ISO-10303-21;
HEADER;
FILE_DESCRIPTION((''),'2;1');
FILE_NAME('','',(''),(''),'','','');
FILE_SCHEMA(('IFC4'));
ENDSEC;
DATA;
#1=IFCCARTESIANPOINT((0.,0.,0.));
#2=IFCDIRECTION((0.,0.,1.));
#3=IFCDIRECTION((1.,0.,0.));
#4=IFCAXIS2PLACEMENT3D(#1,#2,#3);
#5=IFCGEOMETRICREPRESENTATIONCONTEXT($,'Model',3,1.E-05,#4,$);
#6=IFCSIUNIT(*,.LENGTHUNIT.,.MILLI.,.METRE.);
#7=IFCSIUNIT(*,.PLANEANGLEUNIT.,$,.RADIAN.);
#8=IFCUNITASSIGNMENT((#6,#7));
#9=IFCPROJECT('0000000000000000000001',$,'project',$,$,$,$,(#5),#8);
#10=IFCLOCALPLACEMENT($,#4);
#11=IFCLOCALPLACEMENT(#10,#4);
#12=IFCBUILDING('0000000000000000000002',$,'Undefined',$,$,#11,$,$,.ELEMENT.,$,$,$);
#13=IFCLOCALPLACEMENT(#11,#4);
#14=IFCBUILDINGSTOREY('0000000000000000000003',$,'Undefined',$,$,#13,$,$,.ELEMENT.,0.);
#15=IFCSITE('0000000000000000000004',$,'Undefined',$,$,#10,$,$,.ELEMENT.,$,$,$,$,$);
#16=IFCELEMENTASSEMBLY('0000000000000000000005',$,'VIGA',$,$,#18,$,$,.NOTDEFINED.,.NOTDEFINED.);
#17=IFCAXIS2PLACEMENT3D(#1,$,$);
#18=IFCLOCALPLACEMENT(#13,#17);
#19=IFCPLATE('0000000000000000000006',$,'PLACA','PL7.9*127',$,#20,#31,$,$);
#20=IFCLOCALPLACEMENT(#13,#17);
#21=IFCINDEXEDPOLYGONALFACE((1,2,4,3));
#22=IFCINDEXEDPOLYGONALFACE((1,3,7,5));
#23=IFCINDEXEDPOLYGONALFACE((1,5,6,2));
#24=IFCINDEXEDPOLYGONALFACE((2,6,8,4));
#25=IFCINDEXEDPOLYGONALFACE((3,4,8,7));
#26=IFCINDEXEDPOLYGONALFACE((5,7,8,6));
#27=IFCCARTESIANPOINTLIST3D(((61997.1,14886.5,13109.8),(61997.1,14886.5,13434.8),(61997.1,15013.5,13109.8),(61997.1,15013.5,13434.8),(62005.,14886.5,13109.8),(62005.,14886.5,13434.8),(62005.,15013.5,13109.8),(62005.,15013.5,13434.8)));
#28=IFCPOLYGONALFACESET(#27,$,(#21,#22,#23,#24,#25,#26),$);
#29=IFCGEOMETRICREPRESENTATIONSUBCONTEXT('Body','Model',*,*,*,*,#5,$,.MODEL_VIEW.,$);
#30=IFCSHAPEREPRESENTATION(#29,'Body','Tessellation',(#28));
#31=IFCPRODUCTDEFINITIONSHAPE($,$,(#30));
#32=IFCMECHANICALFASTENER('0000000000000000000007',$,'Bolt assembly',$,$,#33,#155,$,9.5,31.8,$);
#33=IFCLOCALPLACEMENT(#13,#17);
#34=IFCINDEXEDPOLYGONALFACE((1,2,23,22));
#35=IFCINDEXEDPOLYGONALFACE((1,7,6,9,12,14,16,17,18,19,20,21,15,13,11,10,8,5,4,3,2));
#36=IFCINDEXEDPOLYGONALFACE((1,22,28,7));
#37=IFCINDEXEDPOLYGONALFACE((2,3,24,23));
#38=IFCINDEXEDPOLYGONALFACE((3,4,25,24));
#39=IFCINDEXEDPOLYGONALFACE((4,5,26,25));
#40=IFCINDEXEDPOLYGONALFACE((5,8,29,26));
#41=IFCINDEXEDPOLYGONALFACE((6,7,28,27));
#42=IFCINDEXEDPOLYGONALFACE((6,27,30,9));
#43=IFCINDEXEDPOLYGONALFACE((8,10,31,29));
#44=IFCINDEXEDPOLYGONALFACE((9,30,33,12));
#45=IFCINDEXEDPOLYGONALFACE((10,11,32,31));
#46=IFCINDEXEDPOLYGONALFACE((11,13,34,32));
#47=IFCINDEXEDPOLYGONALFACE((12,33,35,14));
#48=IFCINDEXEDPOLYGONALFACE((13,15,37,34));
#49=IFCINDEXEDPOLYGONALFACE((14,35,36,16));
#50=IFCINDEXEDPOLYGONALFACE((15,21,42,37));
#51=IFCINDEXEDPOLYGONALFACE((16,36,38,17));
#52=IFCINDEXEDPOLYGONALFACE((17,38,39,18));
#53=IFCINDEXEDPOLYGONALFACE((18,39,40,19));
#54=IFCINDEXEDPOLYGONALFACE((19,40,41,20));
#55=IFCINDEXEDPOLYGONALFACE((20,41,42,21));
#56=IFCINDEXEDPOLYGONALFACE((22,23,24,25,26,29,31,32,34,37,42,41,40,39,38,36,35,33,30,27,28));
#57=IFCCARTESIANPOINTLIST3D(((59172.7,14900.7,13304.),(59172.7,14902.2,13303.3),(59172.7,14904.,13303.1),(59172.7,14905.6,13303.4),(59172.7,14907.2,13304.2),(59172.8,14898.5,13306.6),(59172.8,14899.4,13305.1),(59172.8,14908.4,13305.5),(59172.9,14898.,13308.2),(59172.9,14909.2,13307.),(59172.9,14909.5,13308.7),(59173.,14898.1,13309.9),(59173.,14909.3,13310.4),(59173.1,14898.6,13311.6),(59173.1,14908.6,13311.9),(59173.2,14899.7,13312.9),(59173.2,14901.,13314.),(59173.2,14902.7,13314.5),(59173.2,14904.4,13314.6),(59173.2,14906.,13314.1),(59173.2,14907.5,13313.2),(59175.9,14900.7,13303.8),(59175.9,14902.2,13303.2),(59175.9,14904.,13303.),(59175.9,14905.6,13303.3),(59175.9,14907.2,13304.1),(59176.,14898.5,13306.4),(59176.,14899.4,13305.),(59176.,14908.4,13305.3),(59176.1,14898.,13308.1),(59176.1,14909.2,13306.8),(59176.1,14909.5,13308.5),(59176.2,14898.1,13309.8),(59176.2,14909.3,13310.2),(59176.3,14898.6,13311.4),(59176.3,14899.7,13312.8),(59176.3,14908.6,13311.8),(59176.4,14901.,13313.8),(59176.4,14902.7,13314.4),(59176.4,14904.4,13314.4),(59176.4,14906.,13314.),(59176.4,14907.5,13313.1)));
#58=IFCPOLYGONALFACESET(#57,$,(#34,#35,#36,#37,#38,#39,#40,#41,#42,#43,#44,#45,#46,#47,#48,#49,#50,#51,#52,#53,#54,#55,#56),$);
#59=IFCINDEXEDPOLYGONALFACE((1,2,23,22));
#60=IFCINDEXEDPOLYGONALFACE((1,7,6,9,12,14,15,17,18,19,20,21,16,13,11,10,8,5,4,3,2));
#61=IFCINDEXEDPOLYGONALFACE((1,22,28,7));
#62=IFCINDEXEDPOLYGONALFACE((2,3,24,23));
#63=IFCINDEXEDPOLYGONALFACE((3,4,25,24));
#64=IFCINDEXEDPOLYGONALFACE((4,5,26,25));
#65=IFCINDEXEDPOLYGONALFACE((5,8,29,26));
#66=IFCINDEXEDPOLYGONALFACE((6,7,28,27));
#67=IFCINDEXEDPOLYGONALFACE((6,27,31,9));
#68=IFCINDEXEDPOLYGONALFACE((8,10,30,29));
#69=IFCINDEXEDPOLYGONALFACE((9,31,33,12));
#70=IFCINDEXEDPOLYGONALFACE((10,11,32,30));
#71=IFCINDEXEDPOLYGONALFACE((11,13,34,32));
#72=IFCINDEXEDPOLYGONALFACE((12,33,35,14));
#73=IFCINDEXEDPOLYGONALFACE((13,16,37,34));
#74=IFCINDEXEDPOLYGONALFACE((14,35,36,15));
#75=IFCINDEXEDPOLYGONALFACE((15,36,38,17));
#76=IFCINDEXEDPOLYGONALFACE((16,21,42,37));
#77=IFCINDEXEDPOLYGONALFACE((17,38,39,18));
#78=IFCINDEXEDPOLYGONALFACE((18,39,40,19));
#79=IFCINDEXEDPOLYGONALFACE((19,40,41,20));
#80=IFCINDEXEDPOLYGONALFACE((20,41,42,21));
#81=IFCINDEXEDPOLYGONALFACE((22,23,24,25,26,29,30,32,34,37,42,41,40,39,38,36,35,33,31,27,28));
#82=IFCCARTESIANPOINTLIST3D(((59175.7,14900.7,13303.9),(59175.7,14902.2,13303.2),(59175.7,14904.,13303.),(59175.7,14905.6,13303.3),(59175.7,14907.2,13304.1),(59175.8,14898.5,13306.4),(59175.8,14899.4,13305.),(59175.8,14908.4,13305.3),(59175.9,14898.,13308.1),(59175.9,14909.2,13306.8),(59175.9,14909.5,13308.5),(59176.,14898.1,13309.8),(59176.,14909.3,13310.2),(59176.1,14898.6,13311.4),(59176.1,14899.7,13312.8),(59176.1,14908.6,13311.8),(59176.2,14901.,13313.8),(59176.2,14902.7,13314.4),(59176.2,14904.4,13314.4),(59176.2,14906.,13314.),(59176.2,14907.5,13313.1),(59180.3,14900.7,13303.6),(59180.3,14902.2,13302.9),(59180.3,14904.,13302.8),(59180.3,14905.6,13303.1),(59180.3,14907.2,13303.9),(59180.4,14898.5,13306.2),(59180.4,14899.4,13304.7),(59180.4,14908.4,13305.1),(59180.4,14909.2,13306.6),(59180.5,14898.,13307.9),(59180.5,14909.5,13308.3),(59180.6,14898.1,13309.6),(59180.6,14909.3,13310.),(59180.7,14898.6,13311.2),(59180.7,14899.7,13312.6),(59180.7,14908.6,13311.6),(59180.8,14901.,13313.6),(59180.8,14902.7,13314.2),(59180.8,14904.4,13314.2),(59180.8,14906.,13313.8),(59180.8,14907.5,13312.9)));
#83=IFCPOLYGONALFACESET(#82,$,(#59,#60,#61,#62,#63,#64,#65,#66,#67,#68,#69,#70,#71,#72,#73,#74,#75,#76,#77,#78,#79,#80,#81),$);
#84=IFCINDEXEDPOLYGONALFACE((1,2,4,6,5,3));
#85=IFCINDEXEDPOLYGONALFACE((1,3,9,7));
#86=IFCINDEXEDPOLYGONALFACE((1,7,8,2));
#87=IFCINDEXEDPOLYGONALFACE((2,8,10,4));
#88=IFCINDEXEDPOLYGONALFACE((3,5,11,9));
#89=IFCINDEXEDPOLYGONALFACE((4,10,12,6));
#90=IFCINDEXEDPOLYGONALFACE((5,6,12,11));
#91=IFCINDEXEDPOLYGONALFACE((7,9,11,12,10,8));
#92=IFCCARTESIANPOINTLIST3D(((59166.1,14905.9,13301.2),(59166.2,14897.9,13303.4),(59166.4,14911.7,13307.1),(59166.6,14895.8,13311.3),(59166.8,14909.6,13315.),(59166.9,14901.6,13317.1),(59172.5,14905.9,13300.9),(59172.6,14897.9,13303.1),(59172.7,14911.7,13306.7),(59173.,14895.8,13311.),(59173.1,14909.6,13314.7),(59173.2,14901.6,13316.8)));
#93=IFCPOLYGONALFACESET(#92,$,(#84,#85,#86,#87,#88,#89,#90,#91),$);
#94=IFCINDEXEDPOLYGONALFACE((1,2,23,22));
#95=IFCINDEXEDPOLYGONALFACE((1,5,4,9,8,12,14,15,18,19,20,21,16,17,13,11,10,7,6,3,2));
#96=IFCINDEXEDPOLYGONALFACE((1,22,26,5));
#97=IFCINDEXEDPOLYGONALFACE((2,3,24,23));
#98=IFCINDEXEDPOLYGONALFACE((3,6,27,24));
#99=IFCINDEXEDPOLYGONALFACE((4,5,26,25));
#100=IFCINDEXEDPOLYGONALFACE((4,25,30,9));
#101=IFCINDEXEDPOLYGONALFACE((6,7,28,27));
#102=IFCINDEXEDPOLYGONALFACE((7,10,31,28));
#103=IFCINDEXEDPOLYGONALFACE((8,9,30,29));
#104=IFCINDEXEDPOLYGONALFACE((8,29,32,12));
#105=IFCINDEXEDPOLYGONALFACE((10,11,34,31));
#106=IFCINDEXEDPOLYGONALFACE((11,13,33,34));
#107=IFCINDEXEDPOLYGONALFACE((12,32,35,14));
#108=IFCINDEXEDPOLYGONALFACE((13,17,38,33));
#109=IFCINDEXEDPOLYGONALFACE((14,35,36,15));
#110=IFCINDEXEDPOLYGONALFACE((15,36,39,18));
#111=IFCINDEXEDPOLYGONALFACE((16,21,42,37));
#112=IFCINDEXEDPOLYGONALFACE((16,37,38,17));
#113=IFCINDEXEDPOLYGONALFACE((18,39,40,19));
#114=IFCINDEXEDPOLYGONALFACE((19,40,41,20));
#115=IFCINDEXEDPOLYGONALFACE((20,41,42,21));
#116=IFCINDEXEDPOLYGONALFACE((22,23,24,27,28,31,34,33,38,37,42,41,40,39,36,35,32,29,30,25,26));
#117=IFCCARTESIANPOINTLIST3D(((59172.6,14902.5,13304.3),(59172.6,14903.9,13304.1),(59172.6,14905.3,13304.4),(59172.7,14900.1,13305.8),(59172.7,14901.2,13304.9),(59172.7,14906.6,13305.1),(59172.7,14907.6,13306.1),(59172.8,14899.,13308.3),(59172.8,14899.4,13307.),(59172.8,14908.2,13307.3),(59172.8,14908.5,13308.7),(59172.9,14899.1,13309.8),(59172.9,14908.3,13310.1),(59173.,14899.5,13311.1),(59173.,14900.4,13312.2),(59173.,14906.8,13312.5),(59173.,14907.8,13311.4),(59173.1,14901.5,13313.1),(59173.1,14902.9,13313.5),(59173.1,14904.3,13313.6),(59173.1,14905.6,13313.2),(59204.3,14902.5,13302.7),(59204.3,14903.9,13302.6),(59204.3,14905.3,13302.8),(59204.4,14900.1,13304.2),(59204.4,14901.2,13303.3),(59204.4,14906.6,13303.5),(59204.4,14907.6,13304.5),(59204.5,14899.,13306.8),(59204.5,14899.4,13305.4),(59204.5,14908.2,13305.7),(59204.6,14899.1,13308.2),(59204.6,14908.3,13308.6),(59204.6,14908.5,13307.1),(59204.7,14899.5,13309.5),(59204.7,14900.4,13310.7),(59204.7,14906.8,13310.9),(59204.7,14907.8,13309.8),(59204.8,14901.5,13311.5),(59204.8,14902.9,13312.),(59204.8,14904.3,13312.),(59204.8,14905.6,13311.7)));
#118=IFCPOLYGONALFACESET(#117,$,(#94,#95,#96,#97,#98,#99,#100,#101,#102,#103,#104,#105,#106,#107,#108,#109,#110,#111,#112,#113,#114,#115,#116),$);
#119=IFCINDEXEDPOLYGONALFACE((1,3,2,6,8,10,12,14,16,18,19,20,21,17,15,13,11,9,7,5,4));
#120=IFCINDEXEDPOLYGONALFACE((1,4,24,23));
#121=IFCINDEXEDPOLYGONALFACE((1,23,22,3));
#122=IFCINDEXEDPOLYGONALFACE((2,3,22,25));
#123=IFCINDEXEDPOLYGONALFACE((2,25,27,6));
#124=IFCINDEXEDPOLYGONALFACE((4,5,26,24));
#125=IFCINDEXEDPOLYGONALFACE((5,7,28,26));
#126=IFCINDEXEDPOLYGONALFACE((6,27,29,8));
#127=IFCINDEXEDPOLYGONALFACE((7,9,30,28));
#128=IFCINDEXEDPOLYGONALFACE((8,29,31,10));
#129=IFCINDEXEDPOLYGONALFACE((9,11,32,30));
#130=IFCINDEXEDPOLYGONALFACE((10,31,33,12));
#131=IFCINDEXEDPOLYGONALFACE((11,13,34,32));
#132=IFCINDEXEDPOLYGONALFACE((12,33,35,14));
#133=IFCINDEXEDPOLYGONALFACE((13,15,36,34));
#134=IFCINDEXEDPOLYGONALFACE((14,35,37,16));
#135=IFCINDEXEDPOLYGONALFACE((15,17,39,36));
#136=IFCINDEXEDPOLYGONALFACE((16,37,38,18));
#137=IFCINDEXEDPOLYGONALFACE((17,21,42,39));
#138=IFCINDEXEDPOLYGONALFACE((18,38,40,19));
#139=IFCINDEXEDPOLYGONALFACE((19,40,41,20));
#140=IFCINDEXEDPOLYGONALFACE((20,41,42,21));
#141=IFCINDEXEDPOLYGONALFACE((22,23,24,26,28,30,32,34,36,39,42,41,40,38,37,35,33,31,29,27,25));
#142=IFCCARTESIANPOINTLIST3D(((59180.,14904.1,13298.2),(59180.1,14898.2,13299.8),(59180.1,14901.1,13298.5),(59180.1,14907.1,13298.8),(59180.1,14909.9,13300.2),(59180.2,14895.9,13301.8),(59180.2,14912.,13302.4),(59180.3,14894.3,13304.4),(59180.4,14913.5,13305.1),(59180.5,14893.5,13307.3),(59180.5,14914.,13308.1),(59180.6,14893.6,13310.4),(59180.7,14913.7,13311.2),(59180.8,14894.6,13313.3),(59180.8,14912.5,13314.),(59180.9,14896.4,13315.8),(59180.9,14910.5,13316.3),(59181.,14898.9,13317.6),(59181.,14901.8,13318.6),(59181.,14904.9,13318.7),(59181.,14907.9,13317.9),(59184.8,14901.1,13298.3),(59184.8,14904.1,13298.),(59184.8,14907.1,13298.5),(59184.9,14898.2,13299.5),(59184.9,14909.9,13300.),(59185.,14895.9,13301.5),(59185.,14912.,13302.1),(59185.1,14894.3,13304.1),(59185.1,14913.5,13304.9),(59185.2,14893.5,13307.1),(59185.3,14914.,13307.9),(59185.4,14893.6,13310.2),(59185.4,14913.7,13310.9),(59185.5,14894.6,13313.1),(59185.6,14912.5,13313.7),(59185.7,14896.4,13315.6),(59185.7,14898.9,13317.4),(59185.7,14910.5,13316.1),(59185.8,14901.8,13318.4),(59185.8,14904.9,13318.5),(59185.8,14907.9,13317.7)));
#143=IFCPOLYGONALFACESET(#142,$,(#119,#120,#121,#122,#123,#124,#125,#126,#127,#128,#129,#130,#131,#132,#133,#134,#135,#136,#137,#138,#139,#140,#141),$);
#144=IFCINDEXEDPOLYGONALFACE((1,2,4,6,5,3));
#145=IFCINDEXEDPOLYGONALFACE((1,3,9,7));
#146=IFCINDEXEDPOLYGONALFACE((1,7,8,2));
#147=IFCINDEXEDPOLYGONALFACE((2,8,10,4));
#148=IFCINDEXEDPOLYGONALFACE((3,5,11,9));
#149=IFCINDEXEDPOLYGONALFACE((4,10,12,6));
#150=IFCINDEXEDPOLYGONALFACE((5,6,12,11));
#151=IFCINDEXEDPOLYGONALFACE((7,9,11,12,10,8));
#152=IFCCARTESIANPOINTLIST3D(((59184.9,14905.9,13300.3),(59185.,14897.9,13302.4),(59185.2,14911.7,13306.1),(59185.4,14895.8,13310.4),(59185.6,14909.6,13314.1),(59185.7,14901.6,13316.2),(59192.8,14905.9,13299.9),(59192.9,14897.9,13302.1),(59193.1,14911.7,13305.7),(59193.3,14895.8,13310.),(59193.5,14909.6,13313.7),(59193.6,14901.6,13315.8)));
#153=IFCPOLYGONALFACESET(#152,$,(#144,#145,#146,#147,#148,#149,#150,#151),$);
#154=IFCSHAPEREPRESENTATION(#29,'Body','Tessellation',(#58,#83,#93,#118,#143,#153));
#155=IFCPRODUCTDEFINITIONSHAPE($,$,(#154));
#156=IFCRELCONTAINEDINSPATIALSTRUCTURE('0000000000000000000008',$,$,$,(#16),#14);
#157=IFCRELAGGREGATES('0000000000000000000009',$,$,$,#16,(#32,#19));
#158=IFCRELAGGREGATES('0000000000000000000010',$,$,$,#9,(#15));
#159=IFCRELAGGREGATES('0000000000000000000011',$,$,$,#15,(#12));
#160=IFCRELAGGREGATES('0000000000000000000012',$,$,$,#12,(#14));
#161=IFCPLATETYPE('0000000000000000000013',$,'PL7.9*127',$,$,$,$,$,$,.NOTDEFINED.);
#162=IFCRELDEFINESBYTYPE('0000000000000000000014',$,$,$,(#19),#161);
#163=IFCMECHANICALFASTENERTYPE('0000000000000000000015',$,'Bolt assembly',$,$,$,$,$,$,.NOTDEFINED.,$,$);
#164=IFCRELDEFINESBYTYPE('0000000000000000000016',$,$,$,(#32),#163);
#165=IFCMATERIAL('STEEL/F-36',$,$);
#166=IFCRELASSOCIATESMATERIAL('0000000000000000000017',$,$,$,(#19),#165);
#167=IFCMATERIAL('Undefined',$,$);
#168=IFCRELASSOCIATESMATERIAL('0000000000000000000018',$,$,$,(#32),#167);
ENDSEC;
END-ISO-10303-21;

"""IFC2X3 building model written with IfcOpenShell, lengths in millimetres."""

from ifc_helpers import new_model, si_unit, frame, origin_with_axes, origin_2d_with_axis, place, context, subcontext, project, spatial, polyline, circle, outline, extrude, source, transform, mapped, material, type_object, element, aggregate, save


model = new_model("IFC2X3")

# Units and contexts
model_context = context("Model", 3, precision=1e-05, world=origin_with_axes())
body_context = subcontext(model_context, "Body", "Model", "MODEL_VIEW")
ifc_project = project(units=[si_unit("LENGTHUNIT", "METRE", prefix="MILLI"), si_unit("PLANEANGLEUNIT", "RADIAN")], contexts=[model_context])

# Site, building, storey
site_placement = place(None, origin_with_axes())
site = spatial("IfcSite", under=ifc_project, at=site_placement, Name="Undefined", CompositionType="ELEMENT")
building_placement = place(site_placement, origin_with_axes())
building = spatial("IfcBuilding", under=site, at=building_placement, Name="Undefined", CompositionType="ELEMENT")
storey_placement = place(building_placement, origin_with_axes())
storey = spatial("IfcBuildingStorey", under=building, at=storey_placement, Name="Undefined", CompositionType="ELEMENT", Elevation=0.0)

# Element assembly
assembly_1_placement = place(storey_placement, origin_with_axes())
assembly_1 = element("IfcElementAssembly", 1, at=assembly_1_placement, inside=storey, Name="VIGA", AssemblyPlace="NOTDEFINED", PredefinedType="NOTDEFINED")
ifc_material_1 = material(Name="STEEL/F-36")

# Plate
plate_type_1 = type_object("IfcPlateType", Name="PL7.9*127", PredefinedType="NOTDEFINED")
plate_1_placement = place(assembly_1_placement, frame((62001.0, 14950.0, 13434.8), z_axis=(-1.0, 0.0, 0.0), x_axis=(0.0, 0.0, -1.0)))
plate_1 = element("IfcPlate", 2, at=plate_1_placement, type_object=plate_type_1, material=ifc_material_1, Name="PLACA", Description="PL7.9*127", context=body_context, shape_type="SweptSolid", body=[
    extrude(outline(polyline([(0.0, -63.5), (0.0, 63.5), (325.0, 63.5), (325.0, -63.5), (0.0, -63.5)])), frame((0.0, 0.0, -4.0), z_axis=(0.0, 0.0, 1.0), x_axis=(1.0, 0.0, 0.0)), (0.0, 0.0, 1.0), 7.9),
])

# Shared definitions
mechanical_fastener_type = type_object("IfcMechanicalFastenerType", Name="Bolt assembly")

# Shared definitions
ifc_material_2 = material(Name="Undefined")

# Mechanical fastener
shared_shape_1 = source(origin_with_axes(), body_context, "Body", "SweptSolid", [
    extrude(circle(Radius=5.8, at=origin_2d_with_axis()), frame((0.0, -3.1, 0.0), z_axis=(0.0, 1.0, 0.0), x_axis=(1.0, 0.0, 0.0)), (0.0, 0.0, 1.0), 3.2),
    extrude(circle(Radius=5.8, at=origin_2d_with_axis()), frame((0.0, -0.1, 0.0), z_axis=(0.0, 1.0, 0.0), x_axis=(1.0, 0.0, 0.0)), (0.0, 0.0, 1.0), 4.6),
    extrude(outline(polyline([(7.1, -4.1), (7.1, 4.1), (0.0, 8.2), (-7.1, 4.1), (-7.1, -4.1), (0.0, -8.2), (7.1, -4.1)])), frame((0.0, -9.5, 0.0), z_axis=(0.0, 1.0, 0.0), x_axis=(1.0, 0.0, 0.0)), (0.0, 0.0, 1.0), 6.3),
    extrude(circle(Radius=4.8, at=origin_2d_with_axis()), frame((0.0, -3.2, 0.0), z_axis=(0.0, 1.0, 0.0), x_axis=(1.0, 0.0, 0.0)), (0.0, 0.0, 1.0), 31.8),
    extrude(circle(Radius=10.3, at=origin_2d_with_axis()), frame((0.0, 4.5, 0.0), z_axis=(0.0, 1.0, 0.0), x_axis=(1.0, 0.0, 0.0)), (0.0, 0.0, 1.0), 4.8),
    extrude(outline(polyline([(7.1, -4.1), (7.1, 4.1), (0.0, 8.2), (-7.1, 4.1), (-7.1, -4.1), (0.0, -8.2), (7.1, -4.1)])), frame((0.0, 9.3, 0.0), z_axis=(0.0, 1.0, 0.0), x_axis=(1.0, 0.0, 0.0)), (0.0, 0.0, 1.0), 7.9),
])
mechanical_fastener_1_placement = place(assembly_1_placement, frame((59176.0, 14903.7, 13308.7), z_axis=(0.034712, 0.707107, 0.706254), x_axis=(0.034712, -0.707107, 0.706254)))
mechanical_fastener_1 = element("IfcMechanicalFastener", 3, at=mechanical_fastener_1_placement, type_object=mechanical_fastener_type, material=ifc_material_2, Name="Bolt assembly", NominalDiameter=9.5, NominalLength=31.8, context=body_context, shape_type="MappedRepresentation", body=[
    mapped(shared_shape_1, transform((0.0, 0.0, 0.0))),
])
aggregate(assembly_1, [mechanical_fastener_1, plate_1])

save(model, "model.ifc")
